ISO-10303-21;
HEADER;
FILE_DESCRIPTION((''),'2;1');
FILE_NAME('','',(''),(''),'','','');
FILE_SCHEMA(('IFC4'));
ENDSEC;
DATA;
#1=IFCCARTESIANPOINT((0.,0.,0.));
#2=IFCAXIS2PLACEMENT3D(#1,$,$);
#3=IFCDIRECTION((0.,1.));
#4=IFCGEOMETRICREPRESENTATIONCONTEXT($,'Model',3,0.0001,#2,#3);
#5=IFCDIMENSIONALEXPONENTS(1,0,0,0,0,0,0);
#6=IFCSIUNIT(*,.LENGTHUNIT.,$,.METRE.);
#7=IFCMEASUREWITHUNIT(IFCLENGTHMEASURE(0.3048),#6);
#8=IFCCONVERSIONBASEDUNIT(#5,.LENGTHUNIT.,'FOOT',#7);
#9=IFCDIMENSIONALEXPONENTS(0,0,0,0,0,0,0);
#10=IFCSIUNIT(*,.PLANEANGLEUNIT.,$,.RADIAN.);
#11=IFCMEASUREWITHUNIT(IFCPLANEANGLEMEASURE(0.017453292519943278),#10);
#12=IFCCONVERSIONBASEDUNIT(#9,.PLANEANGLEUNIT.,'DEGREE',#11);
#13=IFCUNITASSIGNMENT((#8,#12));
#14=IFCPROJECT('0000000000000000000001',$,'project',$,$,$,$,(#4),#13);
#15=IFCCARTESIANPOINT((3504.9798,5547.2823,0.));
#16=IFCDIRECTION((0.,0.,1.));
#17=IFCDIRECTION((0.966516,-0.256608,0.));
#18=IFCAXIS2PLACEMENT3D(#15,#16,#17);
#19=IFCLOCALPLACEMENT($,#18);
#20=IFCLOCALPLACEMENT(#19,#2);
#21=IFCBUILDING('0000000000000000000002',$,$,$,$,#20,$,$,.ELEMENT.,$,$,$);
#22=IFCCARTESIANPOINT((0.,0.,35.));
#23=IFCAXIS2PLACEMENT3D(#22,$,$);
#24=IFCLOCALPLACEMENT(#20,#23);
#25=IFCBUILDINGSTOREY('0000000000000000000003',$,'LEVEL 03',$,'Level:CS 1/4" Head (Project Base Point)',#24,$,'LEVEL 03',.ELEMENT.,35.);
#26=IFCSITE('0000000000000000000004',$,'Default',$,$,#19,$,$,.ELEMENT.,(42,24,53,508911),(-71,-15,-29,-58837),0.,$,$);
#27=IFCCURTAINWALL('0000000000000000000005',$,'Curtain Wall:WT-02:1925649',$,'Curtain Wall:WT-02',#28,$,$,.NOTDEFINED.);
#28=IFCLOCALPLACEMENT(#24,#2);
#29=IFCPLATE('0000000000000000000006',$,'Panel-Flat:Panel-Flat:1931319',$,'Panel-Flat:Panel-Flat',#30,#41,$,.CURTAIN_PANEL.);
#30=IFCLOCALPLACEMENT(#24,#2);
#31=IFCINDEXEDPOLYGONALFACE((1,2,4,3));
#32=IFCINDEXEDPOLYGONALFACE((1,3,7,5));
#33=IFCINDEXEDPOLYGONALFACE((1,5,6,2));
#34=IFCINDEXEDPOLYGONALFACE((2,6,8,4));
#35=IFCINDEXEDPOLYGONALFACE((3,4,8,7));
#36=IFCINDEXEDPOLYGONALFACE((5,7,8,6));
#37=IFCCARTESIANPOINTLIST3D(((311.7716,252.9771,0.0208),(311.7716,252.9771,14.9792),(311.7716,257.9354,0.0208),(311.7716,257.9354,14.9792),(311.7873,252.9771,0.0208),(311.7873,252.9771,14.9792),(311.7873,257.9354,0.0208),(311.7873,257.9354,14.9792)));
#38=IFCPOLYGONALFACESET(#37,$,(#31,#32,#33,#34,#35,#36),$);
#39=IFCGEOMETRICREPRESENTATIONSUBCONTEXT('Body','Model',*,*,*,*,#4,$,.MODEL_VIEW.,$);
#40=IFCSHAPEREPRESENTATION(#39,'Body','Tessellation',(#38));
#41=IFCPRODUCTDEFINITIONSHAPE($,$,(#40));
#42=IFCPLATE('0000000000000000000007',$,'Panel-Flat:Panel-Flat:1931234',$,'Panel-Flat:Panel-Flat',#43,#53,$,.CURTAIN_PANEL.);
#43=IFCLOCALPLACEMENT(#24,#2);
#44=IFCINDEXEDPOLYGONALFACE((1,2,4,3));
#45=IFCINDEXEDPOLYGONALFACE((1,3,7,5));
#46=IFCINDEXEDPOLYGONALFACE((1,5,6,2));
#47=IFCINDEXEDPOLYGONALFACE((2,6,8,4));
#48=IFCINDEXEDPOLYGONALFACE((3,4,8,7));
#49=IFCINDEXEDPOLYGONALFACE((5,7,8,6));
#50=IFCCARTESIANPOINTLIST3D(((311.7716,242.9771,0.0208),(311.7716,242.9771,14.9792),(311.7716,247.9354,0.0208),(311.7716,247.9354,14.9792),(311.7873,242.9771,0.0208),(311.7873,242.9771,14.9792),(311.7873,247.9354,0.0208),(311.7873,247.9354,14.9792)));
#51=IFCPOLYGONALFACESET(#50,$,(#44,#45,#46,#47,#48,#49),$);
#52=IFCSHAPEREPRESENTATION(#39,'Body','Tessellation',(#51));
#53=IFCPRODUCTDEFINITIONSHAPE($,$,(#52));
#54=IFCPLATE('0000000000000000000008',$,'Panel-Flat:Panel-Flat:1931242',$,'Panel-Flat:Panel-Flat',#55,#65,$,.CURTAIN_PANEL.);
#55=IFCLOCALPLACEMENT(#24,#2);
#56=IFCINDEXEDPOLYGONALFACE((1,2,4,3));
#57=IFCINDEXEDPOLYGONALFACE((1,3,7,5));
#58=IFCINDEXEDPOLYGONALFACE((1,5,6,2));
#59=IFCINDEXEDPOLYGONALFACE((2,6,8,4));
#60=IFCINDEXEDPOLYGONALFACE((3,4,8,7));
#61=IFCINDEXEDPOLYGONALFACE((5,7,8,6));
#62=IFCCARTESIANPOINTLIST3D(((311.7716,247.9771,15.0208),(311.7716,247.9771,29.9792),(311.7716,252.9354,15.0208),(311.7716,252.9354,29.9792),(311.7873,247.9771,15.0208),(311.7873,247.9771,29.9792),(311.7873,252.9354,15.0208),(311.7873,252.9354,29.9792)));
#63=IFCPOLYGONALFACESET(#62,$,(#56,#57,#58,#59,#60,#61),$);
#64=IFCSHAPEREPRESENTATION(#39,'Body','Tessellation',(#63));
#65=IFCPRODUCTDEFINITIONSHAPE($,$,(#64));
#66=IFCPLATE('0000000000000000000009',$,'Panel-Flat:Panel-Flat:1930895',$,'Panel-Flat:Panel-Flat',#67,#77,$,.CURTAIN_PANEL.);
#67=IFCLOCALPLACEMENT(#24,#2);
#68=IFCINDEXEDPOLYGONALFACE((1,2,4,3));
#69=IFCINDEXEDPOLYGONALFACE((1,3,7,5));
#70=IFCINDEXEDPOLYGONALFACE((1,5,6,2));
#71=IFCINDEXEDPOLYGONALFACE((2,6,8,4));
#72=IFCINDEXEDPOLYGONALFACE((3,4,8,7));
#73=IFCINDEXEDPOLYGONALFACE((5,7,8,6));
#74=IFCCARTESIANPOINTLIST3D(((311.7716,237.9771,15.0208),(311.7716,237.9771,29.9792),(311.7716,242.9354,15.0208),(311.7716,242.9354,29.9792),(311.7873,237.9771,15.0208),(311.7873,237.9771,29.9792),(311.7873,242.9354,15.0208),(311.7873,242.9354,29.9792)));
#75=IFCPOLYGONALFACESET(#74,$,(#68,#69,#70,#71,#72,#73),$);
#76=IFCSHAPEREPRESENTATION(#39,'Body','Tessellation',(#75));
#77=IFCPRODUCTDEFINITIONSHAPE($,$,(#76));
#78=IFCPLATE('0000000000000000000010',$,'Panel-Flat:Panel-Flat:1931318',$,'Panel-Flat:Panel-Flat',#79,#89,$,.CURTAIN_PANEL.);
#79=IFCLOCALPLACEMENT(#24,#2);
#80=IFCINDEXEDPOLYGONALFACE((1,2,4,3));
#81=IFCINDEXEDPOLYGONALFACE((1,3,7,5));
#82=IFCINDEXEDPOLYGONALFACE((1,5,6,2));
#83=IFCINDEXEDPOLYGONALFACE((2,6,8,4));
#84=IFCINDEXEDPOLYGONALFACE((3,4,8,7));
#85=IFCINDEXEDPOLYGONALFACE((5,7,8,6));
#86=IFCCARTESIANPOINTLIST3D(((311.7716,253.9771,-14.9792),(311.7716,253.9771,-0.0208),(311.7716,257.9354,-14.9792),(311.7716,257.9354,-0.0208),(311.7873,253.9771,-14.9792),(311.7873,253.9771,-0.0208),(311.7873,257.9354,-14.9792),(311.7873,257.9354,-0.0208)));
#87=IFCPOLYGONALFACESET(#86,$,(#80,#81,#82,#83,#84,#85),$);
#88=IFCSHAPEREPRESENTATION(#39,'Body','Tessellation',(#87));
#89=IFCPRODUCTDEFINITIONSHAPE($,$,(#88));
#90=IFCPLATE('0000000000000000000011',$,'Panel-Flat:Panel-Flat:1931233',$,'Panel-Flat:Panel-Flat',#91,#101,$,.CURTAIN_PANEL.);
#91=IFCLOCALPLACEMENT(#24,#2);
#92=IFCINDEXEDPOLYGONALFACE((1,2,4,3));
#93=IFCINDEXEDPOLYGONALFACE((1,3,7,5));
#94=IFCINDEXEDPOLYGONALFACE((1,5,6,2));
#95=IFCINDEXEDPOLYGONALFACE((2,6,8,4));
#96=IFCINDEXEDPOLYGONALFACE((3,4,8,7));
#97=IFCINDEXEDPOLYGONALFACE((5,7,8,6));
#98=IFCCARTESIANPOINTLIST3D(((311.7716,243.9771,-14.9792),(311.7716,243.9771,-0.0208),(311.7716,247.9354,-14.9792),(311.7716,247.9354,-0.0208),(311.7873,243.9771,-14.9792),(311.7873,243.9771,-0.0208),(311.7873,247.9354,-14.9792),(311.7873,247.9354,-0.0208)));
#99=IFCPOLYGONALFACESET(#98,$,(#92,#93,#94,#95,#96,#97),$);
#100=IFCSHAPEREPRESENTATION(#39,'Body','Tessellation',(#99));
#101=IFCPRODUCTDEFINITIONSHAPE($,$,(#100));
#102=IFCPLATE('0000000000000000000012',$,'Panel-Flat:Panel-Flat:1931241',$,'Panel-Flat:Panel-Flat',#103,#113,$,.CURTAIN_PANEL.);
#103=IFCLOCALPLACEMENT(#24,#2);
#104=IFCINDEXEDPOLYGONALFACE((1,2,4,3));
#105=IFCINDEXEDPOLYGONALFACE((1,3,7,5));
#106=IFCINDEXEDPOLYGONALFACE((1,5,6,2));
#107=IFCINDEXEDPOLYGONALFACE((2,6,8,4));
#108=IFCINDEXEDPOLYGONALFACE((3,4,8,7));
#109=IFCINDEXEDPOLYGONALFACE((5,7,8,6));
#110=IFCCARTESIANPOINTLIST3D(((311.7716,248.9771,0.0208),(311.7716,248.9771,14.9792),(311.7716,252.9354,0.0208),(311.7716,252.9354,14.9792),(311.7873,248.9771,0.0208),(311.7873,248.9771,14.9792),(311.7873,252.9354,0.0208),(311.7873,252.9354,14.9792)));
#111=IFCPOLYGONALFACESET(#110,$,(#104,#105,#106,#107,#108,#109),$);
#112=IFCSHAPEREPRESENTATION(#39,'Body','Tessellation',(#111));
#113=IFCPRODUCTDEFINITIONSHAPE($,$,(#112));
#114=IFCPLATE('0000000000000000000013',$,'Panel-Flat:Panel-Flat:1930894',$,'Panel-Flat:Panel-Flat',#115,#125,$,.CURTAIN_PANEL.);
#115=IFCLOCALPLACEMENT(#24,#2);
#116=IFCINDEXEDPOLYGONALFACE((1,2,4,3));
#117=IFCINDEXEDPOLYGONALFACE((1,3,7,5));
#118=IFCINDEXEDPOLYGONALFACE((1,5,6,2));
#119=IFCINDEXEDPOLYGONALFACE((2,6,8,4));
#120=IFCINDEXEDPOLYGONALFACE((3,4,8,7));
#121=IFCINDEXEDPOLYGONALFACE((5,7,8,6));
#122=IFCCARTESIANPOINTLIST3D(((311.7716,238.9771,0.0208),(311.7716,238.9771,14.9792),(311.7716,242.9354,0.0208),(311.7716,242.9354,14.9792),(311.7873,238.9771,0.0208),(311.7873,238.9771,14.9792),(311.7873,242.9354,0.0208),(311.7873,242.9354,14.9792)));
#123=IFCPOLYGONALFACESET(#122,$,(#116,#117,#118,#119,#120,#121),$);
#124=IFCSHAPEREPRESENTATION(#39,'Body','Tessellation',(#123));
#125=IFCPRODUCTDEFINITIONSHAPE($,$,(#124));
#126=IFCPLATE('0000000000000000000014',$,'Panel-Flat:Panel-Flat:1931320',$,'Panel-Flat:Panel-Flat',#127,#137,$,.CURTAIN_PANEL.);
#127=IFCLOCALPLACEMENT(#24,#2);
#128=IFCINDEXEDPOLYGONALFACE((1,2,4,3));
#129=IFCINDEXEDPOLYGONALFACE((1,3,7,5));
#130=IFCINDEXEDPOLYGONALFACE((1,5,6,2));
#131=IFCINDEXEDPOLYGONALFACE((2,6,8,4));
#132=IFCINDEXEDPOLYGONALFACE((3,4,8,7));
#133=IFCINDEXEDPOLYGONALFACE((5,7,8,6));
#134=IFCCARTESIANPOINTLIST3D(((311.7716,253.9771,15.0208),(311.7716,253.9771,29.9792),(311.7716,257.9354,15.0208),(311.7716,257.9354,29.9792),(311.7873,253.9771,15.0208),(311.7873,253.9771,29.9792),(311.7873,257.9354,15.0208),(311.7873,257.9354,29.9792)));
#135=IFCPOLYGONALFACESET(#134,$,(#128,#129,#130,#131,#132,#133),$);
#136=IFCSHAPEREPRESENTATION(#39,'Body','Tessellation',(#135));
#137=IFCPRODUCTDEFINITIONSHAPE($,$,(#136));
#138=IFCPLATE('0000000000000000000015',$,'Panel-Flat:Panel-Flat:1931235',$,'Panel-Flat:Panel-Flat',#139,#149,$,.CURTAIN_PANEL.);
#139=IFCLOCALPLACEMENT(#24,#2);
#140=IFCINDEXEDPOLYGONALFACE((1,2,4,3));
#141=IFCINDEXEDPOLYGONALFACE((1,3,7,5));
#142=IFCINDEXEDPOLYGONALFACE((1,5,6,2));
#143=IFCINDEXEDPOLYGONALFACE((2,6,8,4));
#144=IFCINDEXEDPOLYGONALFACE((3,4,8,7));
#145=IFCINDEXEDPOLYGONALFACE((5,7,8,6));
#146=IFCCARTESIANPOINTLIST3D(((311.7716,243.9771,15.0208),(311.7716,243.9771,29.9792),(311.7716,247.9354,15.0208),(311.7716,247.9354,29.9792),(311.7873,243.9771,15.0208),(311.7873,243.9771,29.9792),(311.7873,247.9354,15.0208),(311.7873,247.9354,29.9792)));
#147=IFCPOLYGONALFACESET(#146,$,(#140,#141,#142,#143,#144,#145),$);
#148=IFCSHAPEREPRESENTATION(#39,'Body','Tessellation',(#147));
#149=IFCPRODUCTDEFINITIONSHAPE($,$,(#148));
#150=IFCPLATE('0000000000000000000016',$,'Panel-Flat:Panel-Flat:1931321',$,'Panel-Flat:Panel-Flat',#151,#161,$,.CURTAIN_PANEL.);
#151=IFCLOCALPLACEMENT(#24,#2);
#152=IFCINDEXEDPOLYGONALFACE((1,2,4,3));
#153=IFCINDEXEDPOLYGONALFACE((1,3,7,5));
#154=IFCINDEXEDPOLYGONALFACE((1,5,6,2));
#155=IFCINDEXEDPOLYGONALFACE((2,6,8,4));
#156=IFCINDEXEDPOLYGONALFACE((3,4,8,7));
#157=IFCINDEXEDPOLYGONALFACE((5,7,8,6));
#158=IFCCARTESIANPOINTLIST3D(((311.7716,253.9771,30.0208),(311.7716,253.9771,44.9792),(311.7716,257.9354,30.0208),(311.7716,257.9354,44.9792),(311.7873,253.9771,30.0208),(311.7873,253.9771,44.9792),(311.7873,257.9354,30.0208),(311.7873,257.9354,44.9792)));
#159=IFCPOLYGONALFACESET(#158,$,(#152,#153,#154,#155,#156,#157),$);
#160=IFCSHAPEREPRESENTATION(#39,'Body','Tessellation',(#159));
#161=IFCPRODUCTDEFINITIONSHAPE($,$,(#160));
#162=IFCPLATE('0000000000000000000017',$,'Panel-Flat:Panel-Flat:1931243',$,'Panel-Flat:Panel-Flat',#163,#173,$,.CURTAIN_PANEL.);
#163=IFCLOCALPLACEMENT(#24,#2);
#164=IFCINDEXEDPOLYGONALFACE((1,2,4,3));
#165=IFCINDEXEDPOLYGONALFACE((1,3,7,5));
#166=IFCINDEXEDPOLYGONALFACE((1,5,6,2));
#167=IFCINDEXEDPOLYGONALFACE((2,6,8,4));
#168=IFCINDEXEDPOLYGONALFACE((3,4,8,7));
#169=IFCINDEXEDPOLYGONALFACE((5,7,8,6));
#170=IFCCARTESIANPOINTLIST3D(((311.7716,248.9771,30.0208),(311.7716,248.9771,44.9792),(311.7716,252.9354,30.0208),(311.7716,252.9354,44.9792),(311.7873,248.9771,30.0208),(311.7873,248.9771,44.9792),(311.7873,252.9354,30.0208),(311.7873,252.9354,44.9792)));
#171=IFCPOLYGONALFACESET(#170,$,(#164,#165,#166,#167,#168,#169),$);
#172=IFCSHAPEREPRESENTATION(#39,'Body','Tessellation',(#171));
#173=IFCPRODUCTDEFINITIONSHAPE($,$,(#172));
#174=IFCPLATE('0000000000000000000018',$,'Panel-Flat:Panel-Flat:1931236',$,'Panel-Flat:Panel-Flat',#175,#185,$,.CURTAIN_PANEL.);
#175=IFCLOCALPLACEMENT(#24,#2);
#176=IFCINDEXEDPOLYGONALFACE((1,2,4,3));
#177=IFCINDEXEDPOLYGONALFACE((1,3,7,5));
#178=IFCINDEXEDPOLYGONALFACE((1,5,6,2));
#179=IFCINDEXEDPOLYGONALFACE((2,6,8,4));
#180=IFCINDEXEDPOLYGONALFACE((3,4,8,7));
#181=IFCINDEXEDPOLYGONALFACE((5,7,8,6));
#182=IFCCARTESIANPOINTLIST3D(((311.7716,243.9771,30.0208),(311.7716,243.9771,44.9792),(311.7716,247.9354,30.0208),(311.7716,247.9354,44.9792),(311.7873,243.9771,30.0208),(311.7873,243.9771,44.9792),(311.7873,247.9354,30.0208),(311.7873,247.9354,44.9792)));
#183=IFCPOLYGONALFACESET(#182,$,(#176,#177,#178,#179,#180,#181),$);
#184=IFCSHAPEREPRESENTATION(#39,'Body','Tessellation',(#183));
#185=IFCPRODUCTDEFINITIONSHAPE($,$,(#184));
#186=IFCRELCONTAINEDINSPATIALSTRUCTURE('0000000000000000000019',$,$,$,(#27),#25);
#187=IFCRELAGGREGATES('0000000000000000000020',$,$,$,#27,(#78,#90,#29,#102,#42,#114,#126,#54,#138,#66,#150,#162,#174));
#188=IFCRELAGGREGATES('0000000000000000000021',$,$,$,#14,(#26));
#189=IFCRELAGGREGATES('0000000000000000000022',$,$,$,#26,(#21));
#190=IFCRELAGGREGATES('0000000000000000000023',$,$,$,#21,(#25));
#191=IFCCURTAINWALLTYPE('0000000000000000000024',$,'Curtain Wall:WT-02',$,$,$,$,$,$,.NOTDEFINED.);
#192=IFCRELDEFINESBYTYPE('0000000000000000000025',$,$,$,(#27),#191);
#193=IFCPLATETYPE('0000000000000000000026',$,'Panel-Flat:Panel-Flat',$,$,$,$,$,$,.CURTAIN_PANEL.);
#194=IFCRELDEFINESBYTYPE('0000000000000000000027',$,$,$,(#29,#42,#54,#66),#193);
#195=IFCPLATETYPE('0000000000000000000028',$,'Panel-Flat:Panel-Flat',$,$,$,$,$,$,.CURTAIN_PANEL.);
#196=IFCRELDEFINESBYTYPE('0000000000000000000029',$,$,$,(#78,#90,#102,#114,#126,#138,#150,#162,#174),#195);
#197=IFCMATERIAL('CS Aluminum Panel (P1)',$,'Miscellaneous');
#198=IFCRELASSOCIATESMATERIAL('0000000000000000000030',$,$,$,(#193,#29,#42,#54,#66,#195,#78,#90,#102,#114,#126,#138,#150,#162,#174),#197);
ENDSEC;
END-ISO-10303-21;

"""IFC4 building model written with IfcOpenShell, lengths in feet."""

from ifc_helpers import new_model, entity, si_unit, converted_unit, direction, frame, origin, place, context, subcontext, project, spatial, indexed_curve, outline, extrude, source, transform, mapped, material, type_object, type_shapes, element, aggregate, save


model = new_model("IFC4")

# Units and contexts
model_context = context("Model", 3, precision=0.0001, world=origin(), true_north=direction((0.0, 1.0)))
body_context = subcontext(model_context, "Body", "Model", "MODEL_VIEW")
ifc_project = project(units=[converted_unit("LENGTHUNIT", "FOOT", entity("IfcLengthMeasure", 0.3048), si_unit("LENGTHUNIT", "METRE"), dimensions=[1, 0, 0, 0, 0, 0, 0]), converted_unit("PLANEANGLEUNIT", "DEGREE", entity("IfcPlaneAngleMeasure", 0.017453292519943278), si_unit("PLANEANGLEUNIT", "RADIAN"), dimensions=[0, 0, 0, 0, 0, 0, 0])], contexts=[model_context])

# Site, building, storey
site_placement = place(None, frame((3504.9798, 5547.2823, 0.0), z_axis=(0.0, 0.0, 1.0), x_axis=(0.966516, -0.256608, 0.0)))
site = spatial("IfcSite", under=ifc_project, at=site_placement, Name="Default", CompositionType="ELEMENT", RefLatitude=(42, 24, 53, 508911), RefLongitude=(-71, -15, -29, -58837), RefElevation=0.0)
building_placement = place(site_placement, origin())
building = spatial("IfcBuilding", under=site, at=building_placement, CompositionType="ELEMENT")
storey_placement = place(building_placement, frame((0.0, 0.0, 35.0)))
storey = spatial("IfcBuildingStorey", under=building, at=storey_placement, Name="LEVEL 03", ObjectType="Level:CS 1/4\" Head (Project Base Point)", LongName="LEVEL 03", CompositionType="ELEMENT", Elevation=35.0)

# Curtain wall, plates
curtain_wall_type = type_object("IfcCurtainWallType", Name="Curtain Wall:WT-02", PredefinedType="NOTDEFINED")
curtain_wall_1_placement = place(storey_placement, frame((0.0, 0.0, -35.0)))
curtain_wall_1 = element("IfcCurtainWall", 1, at=curtain_wall_1_placement, inside=storey, type_object=curtain_wall_type, Name="Curtain Wall:WT-02:1925649", ObjectType="Curtain Wall:WT-02", PredefinedType="NOTDEFINED")
ifc_material_1 = material(Name="CS Aluminum Panel (P1)", Category="Miscellaneous")
plate_type_1 = type_object("IfcPlateType", Name="Panel-Flat:Panel-Flat", PredefinedType="CURTAIN_PANEL", material=ifc_material_1)
shared_shape_1 = source(origin(), body_context, "Body", "SweptSolid", [
    extrude(outline(indexed_curve([(-0.0078, -2.4792), (0.0078, -2.4792), (0.0078, 2.4792), (-0.0078, 2.4792), (-0.0078, -2.4792)], self_intersect=False)), frame((2.4792, 0.0078, 0.0), z_axis=(0.0, 0.0, 1.0), x_axis=(0.0, -1.0, 0.0)), (0.0, 0.0, 1.0), 14.9583),
])
type_shapes(plate_type_1, [shared_shape_1])
plate_1_placement = place(curtain_wall_1_placement, frame((311.7716, 257.9354, 35.0208), z_axis=(0.0, 0.0, 1.0), x_axis=(0.0, -1.0, 0.0)))
plate_1 = element("IfcPlate", 2, at=plate_1_placement, type_object=plate_type_1, material=ifc_material_1, Name="Panel-Flat:Panel-Flat:1931319", ObjectType="Panel-Flat:Panel-Flat", PredefinedType="CURTAIN_PANEL", context=body_context, shape_type="MappedRepresentation", body=[
    mapped(shared_shape_1, transform((0.0, 0.0, 0.0), scale=1.0)),
])
plate_2_placement = place(curtain_wall_1_placement, frame((311.7716, 247.9354, 35.0208), z_axis=(0.0, 0.0, 1.0), x_axis=(0.0, -1.0, 0.0)))
plate_2 = element("IfcPlate", 3, at=plate_2_placement, type_object=plate_type_1, material=ifc_material_1, Name="Panel-Flat:Panel-Flat:1931234", ObjectType="Panel-Flat:Panel-Flat", PredefinedType="CURTAIN_PANEL", context=body_context, shape_type="MappedRepresentation", body=[
    mapped(shared_shape_1, transform((0.0, 0.0, 0.0), scale=1.0)),
])
plate_3_placement = place(curtain_wall_1_placement, frame((311.7716, 252.9354, 50.0208), z_axis=(0.0, 0.0, 1.0), x_axis=(0.0, -1.0, 0.0)))
plate_3 = element("IfcPlate", 4, at=plate_3_placement, type_object=plate_type_1, material=ifc_material_1, Name="Panel-Flat:Panel-Flat:1931242", ObjectType="Panel-Flat:Panel-Flat", PredefinedType="CURTAIN_PANEL", context=body_context, shape_type="MappedRepresentation", body=[
    mapped(shared_shape_1, transform((0.0, 0.0, 0.0), scale=1.0)),
])
plate_4_placement = place(curtain_wall_1_placement, frame((311.7716, 242.9354, 50.0208), z_axis=(0.0, 0.0, 1.0), x_axis=(0.0, -1.0, 0.0)))
plate_4 = element("IfcPlate", 5, at=plate_4_placement, type_object=plate_type_1, material=ifc_material_1, Name="Panel-Flat:Panel-Flat:1930895", ObjectType="Panel-Flat:Panel-Flat", PredefinedType="CURTAIN_PANEL", context=body_context, shape_type="MappedRepresentation", body=[
    mapped(shared_shape_1, transform((0.0, 0.0, 0.0), scale=1.0)),
])
plate_type_2 = type_object("IfcPlateType", Name="Panel-Flat:Panel-Flat", PredefinedType="CURTAIN_PANEL", material=ifc_material_1)
shared_shape_2 = source(origin(), body_context, "Body", "SweptSolid", [
    extrude(outline(indexed_curve([(-0.0078, -1.9792), (0.0078, -1.9792), (0.0078, 1.9792), (-0.0078, 1.9792), (-0.0078, -1.9792)], self_intersect=False)), frame((1.9792, 0.0078, 0.0), z_axis=(0.0, 0.0, 1.0), x_axis=(0.0, -1.0, 0.0)), (0.0, 0.0, 1.0), 14.9583),
])
type_shapes(plate_type_2, [shared_shape_2])
plate_5_placement = place(curtain_wall_1_placement, frame((311.7716, 257.9354, 20.0208), z_axis=(0.0, 0.0, 1.0), x_axis=(0.0, -1.0, 0.0)))
plate_5 = element("IfcPlate", 6, at=plate_5_placement, type_object=plate_type_2, material=ifc_material_1, Name="Panel-Flat:Panel-Flat:1931318", ObjectType="Panel-Flat:Panel-Flat", PredefinedType="CURTAIN_PANEL", context=body_context, shape_type="MappedRepresentation", body=[
    mapped(shared_shape_2, transform((0.0, 0.0, 0.0), scale=1.0)),
])
plate_6_placement = place(curtain_wall_1_placement, frame((311.7716, 247.9354, 20.0208), z_axis=(0.0, 0.0, 1.0), x_axis=(0.0, -1.0, 0.0)))
plate_6 = element("IfcPlate", 7, at=plate_6_placement, type_object=plate_type_2, material=ifc_material_1, Name="Panel-Flat:Panel-Flat:1931233", ObjectType="Panel-Flat:Panel-Flat", PredefinedType="CURTAIN_PANEL", context=body_context, shape_type="MappedRepresentation", body=[
    mapped(shared_shape_2, transform((0.0, 0.0, 0.0), scale=1.0)),
])
plate_7_placement = place(curtain_wall_1_placement, frame((311.7716, 252.9354, 35.0208), z_axis=(0.0, 0.0, 1.0), x_axis=(0.0, -1.0, 0.0)))
plate_7 = element("IfcPlate", 8, at=plate_7_placement, type_object=plate_type_2, material=ifc_material_1, Name="Panel-Flat:Panel-Flat:1931241", ObjectType="Panel-Flat:Panel-Flat", PredefinedType="CURTAIN_PANEL", context=body_context, shape_type="MappedRepresentation", body=[
    mapped(shared_shape_2, transform((0.0, 0.0, 0.0), scale=1.0)),
])
plate_8_placement = place(curtain_wall_1_placement, frame((311.7716, 242.9354, 35.0208), z_axis=(0.0, 0.0, 1.0), x_axis=(0.0, -1.0, 0.0)))
plate_8 = element("IfcPlate", 9, at=plate_8_placement, type_object=plate_type_2, material=ifc_material_1, Name="Panel-Flat:Panel-Flat:1930894", ObjectType="Panel-Flat:Panel-Flat", PredefinedType="CURTAIN_PANEL", context=body_context, shape_type="MappedRepresentation", body=[
    mapped(shared_shape_2, transform((0.0, 0.0, 0.0), scale=1.0)),
])
plate_9_placement = place(curtain_wall_1_placement, frame((311.7716, 257.9354, 50.0208), z_axis=(0.0, 0.0, 1.0), x_axis=(0.0, -1.0, 0.0)))
plate_9 = element("IfcPlate", 10, at=plate_9_placement, type_object=plate_type_2, material=ifc_material_1, Name="Panel-Flat:Panel-Flat:1931320", ObjectType="Panel-Flat:Panel-Flat", PredefinedType="CURTAIN_PANEL", context=body_context, shape_type="MappedRepresentation", body=[
    mapped(shared_shape_2, transform((0.0, 0.0, 0.0), scale=1.0)),
])
plate_10_placement = place(curtain_wall_1_placement, frame((311.7716, 247.9354, 50.0208), z_axis=(0.0, 0.0, 1.0), x_axis=(0.0, -1.0, 0.0)))
plate_10 = element("IfcPlate", 11, at=plate_10_placement, type_object=plate_type_2, material=ifc_material_1, Name="Panel-Flat:Panel-Flat:1931235", ObjectType="Panel-Flat:Panel-Flat", PredefinedType="CURTAIN_PANEL", context=body_context, shape_type="MappedRepresentation", body=[
    mapped(shared_shape_2, transform((0.0, 0.0, 0.0), scale=1.0)),
])
plate_11_placement = place(curtain_wall_1_placement, frame((311.7716, 257.9354, 65.0208), z_axis=(0.0, 0.0, 1.0), x_axis=(0.0, -1.0, 0.0)))
plate_11 = element("IfcPlate", 12, at=plate_11_placement, type_object=plate_type_2, material=ifc_material_1, Name="Panel-Flat:Panel-Flat:1931321", ObjectType="Panel-Flat:Panel-Flat", PredefinedType="CURTAIN_PANEL", context=body_context, shape_type="MappedRepresentation", body=[
    mapped(shared_shape_2, transform((0.0, 0.0, 0.0), scale=1.0)),
])
plate_12_placement = place(curtain_wall_1_placement, frame((311.7716, 252.9354, 65.0208), z_axis=(0.0, 0.0, 1.0), x_axis=(0.0, -1.0, 0.0)))
plate_12 = element("IfcPlate", 13, at=plate_12_placement, type_object=plate_type_2, material=ifc_material_1, Name="Panel-Flat:Panel-Flat:1931243", ObjectType="Panel-Flat:Panel-Flat", PredefinedType="CURTAIN_PANEL", context=body_context, shape_type="MappedRepresentation", body=[
    mapped(shared_shape_2, transform((0.0, 0.0, 0.0), scale=1.0)),
])
plate_13_placement = place(curtain_wall_1_placement, frame((311.7716, 247.9354, 65.0208), z_axis=(0.0, 0.0, 1.0), x_axis=(0.0, -1.0, 0.0)))
plate_13 = element("IfcPlate", 14, at=plate_13_placement, type_object=plate_type_2, material=ifc_material_1, Name="Panel-Flat:Panel-Flat:1931236", ObjectType="Panel-Flat:Panel-Flat", PredefinedType="CURTAIN_PANEL", context=body_context, shape_type="MappedRepresentation", body=[
    mapped(shared_shape_2, transform((0.0, 0.0, 0.0), scale=1.0)),
])
aggregate(curtain_wall_1, [plate_5, plate_6, plate_1, plate_7, plate_2, plate_8, plate_9, plate_3, plate_10, plate_4, plate_11, plate_12, plate_13])

save(model, "model.ifc")
